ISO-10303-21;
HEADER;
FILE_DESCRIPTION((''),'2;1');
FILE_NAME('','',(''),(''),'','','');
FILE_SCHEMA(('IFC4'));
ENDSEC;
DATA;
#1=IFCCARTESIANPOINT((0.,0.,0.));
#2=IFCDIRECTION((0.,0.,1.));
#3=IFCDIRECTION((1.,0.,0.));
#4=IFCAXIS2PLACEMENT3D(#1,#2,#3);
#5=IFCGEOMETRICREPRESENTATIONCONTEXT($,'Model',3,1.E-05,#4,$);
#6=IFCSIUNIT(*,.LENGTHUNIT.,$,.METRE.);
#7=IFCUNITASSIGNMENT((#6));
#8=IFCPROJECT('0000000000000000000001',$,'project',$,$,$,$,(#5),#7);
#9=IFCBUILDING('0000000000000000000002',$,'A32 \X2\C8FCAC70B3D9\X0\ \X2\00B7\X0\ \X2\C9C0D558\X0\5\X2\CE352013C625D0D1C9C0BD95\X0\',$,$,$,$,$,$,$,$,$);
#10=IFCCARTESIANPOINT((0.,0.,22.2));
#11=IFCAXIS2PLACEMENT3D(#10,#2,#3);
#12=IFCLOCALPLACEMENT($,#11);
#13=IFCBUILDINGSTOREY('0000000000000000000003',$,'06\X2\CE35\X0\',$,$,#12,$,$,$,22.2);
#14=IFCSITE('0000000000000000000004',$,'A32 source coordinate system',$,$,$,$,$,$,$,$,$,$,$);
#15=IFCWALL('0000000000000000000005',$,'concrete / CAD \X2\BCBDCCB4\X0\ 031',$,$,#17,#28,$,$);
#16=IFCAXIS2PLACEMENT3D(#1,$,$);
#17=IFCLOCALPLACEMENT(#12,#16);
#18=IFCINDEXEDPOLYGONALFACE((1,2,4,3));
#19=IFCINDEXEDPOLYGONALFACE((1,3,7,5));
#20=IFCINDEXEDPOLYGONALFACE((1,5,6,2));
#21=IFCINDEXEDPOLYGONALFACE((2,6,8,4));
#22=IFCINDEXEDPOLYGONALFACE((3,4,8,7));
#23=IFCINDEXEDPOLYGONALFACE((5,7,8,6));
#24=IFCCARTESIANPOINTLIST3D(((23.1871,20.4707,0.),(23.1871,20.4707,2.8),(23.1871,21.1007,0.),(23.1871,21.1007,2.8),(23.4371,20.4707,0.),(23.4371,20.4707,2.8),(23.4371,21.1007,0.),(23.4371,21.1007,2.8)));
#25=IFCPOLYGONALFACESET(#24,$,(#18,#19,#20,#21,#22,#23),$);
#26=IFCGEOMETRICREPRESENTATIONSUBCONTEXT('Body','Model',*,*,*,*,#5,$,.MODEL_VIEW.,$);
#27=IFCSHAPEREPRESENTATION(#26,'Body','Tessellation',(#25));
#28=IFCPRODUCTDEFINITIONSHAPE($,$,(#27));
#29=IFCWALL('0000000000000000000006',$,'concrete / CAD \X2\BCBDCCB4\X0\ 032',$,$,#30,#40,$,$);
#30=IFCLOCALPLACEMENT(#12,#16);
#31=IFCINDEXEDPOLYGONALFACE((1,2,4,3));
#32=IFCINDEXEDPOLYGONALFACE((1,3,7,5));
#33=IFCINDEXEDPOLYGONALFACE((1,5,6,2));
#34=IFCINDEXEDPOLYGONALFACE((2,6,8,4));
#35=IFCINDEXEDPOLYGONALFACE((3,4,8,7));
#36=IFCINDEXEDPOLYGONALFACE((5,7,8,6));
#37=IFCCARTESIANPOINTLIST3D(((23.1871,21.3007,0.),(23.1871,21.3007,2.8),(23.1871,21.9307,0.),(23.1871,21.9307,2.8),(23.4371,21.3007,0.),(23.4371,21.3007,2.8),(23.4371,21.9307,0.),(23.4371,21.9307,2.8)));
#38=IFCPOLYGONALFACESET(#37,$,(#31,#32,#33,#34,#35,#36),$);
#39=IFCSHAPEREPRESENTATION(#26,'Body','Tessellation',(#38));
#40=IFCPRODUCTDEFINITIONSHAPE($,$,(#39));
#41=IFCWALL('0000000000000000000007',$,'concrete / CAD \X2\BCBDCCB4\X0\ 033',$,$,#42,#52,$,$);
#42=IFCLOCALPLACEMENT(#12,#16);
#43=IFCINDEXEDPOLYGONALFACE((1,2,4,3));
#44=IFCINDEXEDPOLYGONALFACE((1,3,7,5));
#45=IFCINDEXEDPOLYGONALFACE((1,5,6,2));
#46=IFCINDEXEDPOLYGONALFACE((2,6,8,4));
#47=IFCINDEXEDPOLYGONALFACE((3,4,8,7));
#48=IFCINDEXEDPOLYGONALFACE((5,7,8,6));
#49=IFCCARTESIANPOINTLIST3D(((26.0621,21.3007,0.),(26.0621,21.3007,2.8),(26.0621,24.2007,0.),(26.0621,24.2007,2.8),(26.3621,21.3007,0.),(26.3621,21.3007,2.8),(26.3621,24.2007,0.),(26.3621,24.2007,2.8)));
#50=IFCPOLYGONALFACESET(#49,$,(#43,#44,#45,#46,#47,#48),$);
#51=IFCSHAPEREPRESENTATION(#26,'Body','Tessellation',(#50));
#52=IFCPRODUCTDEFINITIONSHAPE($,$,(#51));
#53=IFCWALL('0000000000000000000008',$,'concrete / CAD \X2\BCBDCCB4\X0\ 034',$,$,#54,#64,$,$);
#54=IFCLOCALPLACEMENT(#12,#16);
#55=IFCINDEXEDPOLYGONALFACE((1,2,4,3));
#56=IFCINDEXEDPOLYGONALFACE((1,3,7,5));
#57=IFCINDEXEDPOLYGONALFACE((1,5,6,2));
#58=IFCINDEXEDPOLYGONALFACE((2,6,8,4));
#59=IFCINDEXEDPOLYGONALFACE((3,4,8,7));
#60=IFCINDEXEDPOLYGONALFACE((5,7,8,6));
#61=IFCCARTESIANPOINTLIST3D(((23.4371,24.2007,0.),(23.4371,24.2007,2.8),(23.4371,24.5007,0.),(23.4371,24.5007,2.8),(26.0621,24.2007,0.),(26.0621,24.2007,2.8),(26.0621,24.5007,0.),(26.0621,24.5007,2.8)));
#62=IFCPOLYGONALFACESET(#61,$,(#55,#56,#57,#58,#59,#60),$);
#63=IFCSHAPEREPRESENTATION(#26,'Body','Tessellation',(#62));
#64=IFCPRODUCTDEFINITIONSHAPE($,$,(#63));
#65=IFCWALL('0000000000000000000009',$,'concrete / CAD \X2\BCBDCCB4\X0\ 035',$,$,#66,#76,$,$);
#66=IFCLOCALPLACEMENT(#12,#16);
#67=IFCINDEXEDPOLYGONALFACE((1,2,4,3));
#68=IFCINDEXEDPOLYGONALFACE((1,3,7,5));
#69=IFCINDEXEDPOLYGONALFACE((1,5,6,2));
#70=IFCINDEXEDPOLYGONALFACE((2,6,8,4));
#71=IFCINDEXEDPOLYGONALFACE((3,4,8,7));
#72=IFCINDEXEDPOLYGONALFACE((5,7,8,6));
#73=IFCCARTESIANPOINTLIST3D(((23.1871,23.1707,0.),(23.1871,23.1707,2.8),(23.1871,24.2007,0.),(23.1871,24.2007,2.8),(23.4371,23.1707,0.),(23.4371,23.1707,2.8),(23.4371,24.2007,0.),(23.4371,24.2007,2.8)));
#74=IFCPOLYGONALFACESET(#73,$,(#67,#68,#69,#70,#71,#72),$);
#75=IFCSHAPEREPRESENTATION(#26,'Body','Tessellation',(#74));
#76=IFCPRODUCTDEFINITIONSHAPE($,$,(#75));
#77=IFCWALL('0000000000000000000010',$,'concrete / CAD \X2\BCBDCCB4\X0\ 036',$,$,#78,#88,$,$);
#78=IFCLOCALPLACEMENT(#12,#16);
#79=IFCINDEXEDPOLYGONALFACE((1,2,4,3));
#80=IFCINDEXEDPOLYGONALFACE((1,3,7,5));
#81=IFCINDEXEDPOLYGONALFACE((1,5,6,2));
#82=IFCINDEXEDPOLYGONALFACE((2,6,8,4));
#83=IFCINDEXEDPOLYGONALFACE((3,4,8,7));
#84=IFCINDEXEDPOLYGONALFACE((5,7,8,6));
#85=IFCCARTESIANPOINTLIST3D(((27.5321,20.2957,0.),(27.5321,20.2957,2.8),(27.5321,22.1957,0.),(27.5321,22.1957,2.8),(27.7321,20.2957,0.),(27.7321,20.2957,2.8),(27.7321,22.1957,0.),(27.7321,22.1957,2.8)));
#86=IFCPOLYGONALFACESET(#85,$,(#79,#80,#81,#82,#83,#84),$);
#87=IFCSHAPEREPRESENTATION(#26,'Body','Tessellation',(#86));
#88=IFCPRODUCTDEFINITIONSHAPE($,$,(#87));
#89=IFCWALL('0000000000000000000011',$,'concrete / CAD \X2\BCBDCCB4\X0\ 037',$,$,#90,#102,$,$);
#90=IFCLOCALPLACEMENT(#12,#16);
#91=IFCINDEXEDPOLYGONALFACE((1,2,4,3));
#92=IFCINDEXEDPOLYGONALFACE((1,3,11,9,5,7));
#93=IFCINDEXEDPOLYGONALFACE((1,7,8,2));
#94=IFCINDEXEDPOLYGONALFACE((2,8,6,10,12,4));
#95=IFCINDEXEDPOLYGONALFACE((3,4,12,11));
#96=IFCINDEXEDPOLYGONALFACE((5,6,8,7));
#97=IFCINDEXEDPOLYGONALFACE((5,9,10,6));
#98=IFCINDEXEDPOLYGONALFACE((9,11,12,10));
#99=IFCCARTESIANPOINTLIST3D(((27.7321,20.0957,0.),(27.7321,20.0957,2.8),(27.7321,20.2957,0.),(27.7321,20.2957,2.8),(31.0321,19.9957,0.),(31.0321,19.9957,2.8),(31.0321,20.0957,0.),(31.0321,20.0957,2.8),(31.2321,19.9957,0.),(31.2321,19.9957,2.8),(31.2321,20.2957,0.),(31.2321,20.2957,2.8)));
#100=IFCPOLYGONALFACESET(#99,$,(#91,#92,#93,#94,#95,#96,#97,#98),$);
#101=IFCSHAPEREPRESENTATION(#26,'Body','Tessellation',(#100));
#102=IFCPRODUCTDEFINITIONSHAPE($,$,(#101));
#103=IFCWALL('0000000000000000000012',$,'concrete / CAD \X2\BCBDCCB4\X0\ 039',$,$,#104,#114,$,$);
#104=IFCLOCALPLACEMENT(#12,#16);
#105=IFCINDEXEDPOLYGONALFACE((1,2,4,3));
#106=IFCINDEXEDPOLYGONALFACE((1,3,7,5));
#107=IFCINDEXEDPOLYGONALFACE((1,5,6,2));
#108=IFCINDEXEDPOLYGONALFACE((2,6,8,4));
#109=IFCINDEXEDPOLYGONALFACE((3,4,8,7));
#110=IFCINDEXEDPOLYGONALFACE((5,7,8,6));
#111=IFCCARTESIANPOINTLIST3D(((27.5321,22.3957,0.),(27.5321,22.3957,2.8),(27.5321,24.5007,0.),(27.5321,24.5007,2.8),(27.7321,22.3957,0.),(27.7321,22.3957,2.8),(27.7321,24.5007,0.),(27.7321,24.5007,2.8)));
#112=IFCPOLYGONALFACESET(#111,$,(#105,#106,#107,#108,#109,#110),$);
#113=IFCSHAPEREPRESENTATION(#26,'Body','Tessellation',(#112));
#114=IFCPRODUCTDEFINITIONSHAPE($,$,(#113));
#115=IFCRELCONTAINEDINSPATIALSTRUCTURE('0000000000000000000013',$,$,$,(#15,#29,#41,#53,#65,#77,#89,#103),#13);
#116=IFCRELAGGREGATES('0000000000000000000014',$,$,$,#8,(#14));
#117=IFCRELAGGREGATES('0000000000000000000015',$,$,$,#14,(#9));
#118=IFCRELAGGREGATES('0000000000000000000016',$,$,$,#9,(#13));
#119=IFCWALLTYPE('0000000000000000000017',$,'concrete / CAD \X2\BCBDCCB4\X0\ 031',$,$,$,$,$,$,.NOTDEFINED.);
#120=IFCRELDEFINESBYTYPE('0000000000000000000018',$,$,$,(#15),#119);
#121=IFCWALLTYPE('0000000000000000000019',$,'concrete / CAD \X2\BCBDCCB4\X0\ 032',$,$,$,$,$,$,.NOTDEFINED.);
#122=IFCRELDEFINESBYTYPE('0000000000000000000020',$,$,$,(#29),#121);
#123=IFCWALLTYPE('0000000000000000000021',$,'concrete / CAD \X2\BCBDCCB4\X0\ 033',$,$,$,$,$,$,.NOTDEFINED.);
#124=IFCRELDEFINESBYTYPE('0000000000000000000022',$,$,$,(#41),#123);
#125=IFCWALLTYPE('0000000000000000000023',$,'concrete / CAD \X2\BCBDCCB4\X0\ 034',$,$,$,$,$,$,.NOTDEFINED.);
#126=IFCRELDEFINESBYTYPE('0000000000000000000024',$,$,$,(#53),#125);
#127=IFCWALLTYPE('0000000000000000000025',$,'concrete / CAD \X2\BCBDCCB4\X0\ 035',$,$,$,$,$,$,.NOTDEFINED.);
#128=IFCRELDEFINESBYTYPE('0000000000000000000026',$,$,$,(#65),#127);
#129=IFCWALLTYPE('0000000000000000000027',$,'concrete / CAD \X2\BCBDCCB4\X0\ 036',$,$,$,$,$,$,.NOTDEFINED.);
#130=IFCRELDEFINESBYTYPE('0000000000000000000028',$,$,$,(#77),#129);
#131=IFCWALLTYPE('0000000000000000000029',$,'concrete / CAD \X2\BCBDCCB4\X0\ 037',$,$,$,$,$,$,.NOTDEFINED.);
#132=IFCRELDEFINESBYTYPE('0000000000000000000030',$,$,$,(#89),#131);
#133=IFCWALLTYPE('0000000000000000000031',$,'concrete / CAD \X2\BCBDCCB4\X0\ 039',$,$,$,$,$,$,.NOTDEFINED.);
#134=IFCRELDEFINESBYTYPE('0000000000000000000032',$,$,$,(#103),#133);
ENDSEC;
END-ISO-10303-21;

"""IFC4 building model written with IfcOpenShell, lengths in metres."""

from ifc_helpers import new_model, si_unit, frame, origin, origin_with_axes, place, context, subcontext, project, spatial, polyline, outline, extrude, source, transform, mapped, type_object, type_shapes, element, save


model = new_model("IFC4")

# Units and contexts
model_context = context("Model", 3, precision=1e-05, world=origin_with_axes())
body_context = subcontext(model_context, "Body", "Model", "MODEL_VIEW")
ifc_project = project(units=[si_unit("LENGTHUNIT", "METRE")], contexts=[model_context])

# Site, building, storey
site = spatial("IfcSite", under=ifc_project, Name="A32 source coordinate system")
building = spatial("IfcBuilding", under=site, Name="A32 주거동 · 지하5층–옥탑지붕")
storey_placement = place(None, frame((0.0, 0.0, 22.2), z_axis=(0.0, 0.0, 1.0), x_axis=(1.0, 0.0, 0.0)))
storey = spatial("IfcBuildingStorey", under=building, at=storey_placement, Name="06층", Elevation=22.2)

# Walls
wall_type_1 = type_object("IfcWallType", Name="concrete / CAD 벽체 031", PredefinedType="NOTDEFINED")
shared_shape_1 = source(origin(), body_context, "Body", "SweptSolid", [
    extrude(outline(polyline([(23.1871, 20.4707), (23.1871, 21.1007), (23.4371, 21.1007), (23.4371, 20.4707), (23.1871, 20.4707)])), origin(), (0.0, 0.0, 1.0), 2.8),
])
type_shapes(wall_type_1, [shared_shape_1])
wall_1_placement = place(storey_placement, origin_with_axes())
element("IfcWall", 1, at=wall_1_placement, inside=storey, type_object=wall_type_1, Name="concrete / CAD 벽체 031", context=body_context, shape_type="MappedRepresentation", body=[
    mapped(shared_shape_1, transform((0.0, 0.0, 0.0), scale=1.0)),
])
wall_type_2 = type_object("IfcWallType", Name="concrete / CAD 벽체 032", PredefinedType="NOTDEFINED")
shared_shape_2 = source(origin(), body_context, "Body", "SweptSolid", [
    extrude(outline(polyline([(23.4371, 21.9307), (23.4371, 21.3007), (23.1871, 21.3007), (23.1871, 21.9307), (23.4371, 21.9307)])), origin(), (0.0, 0.0, 1.0), 2.8),
])
type_shapes(wall_type_2, [shared_shape_2])
wall_2_placement = place(storey_placement, origin_with_axes())
element("IfcWall", 2, at=wall_2_placement, inside=storey, type_object=wall_type_2, Name="concrete / CAD 벽체 032", context=body_context, shape_type="MappedRepresentation", body=[
    mapped(shared_shape_2, transform((0.0, 0.0, 0.0), scale=1.0)),
])
wall_type_3 = type_object("IfcWallType", Name="concrete / CAD 벽체 033", PredefinedType="NOTDEFINED")
shared_shape_3 = source(origin(), body_context, "Body", "SweptSolid", [
    extrude(outline(polyline([(26.3621, 24.2007), (26.3621, 21.3007), (26.0621, 21.3007), (26.0621, 24.2007), (26.3621, 24.2007)])), origin(), (0.0, 0.0, 1.0), 2.8),
])
type_shapes(wall_type_3, [shared_shape_3])
wall_3_placement = place(storey_placement, origin_with_axes())
element("IfcWall", 3, at=wall_3_placement, inside=storey, type_object=wall_type_3, Name="concrete / CAD 벽체 033", context=body_context, shape_type="MappedRepresentation", body=[
    mapped(shared_shape_3, transform((0.0, 0.0, 0.0), scale=1.0)),
])
wall_type_4 = type_object("IfcWallType", Name="concrete / CAD 벽체 034", PredefinedType="NOTDEFINED")
shared_shape_4 = source(origin(), body_context, "Body", "SweptSolid", [
    extrude(outline(polyline([(23.4371, 24.5007), (26.0621, 24.5007), (26.0621, 24.2007), (23.4371, 24.2007), (23.4371, 24.5007)])), origin(), (0.0, 0.0, 1.0), 2.8),
])
type_shapes(wall_type_4, [shared_shape_4])
wall_4_placement = place(storey_placement, origin_with_axes())
element("IfcWall", 4, at=wall_4_placement, inside=storey, type_object=wall_type_4, Name="concrete / CAD 벽체 034", context=body_context, shape_type="MappedRepresentation", body=[
    mapped(shared_shape_4, transform((0.0, 0.0, 0.0), scale=1.0)),
])
wall_type_5 = type_object("IfcWallType", Name="concrete / CAD 벽체 035", PredefinedType="NOTDEFINED")
shared_shape_5 = source(origin(), body_context, "Body", "SweptSolid", [
    extrude(outline(polyline([(23.1871, 23.1707), (23.1871, 24.2007), (23.4371, 24.2007), (23.4371, 23.1707), (23.1871, 23.1707)])), origin(), (0.0, 0.0, 1.0), 2.8),
])
type_shapes(wall_type_5, [shared_shape_5])
wall_5_placement = place(storey_placement, origin_with_axes())
element("IfcWall", 5, at=wall_5_placement, inside=storey, type_object=wall_type_5, Name="concrete / CAD 벽체 035", context=body_context, shape_type="MappedRepresentation", body=[
    mapped(shared_shape_5, transform((0.0, 0.0, 0.0), scale=1.0)),
])
wall_type_6 = type_object("IfcWallType", Name="concrete / CAD 벽체 036", PredefinedType="NOTDEFINED")
shared_shape_6 = source(origin(), body_context, "Body", "SweptSolid", [
    extrude(outline(polyline([(27.7321, 22.1957), (27.7321, 20.2957), (27.5321, 20.2957), (27.5321, 22.1957), (27.7321, 22.1957)])), origin(), (0.0, 0.0, 1.0), 2.8),
])
type_shapes(wall_type_6, [shared_shape_6])
wall_6_placement = place(storey_placement, origin_with_axes())
element("IfcWall", 6, at=wall_6_placement, inside=storey, type_object=wall_type_6, Name="concrete / CAD 벽체 036", context=body_context, shape_type="MappedRepresentation", body=[
    mapped(shared_shape_6, transform((0.0, 0.0, 0.0), scale=1.0)),
])
wall_type_7 = type_object("IfcWallType", Name="concrete / CAD 벽체 037", PredefinedType="NOTDEFINED")
shared_shape_7 = source(origin(), body_context, "Body", "SweptSolid", [
    extrude(outline(polyline([(31.2321, 19.9957), (31.0321, 19.9957), (31.0321, 20.0957), (27.7321, 20.0957), (27.7321, 20.2957), (31.2321, 20.2957), (31.2321, 19.9957)])), origin(), (0.0, 0.0, 1.0), 2.8),
])
type_shapes(wall_type_7, [shared_shape_7])
wall_7_placement = place(storey_placement, origin_with_axes())
element("IfcWall", 7, at=wall_7_placement, inside=storey, type_object=wall_type_7, Name="concrete / CAD 벽체 037", context=body_context, shape_type="MappedRepresentation", body=[
    mapped(shared_shape_7, transform((0.0, 0.0, 0.0), scale=1.0)),
])
wall_type_8 = type_object("IfcWallType", Name="concrete / CAD 벽체 039", PredefinedType="NOTDEFINED")
shared_shape_8 = source(origin(), body_context, "Body", "SweptSolid", [
    extrude(outline(polyline([(27.7321, 24.5007), (27.7321, 22.3957), (27.5321, 22.3957), (27.5321, 24.5007), (27.7321, 24.5007)])), origin(), (0.0, 0.0, 1.0), 2.8),
])
type_shapes(wall_type_8, [shared_shape_8])
wall_8_placement = place(storey_placement, origin_with_axes())
element("IfcWall", 8, at=wall_8_placement, inside=storey, type_object=wall_type_8, Name="concrete / CAD 벽체 039", context=body_context, shape_type="MappedRepresentation", body=[
    mapped(shared_shape_8, transform((0.0, 0.0, 0.0), scale=1.0)),
])

save(model, "model.ifc")
